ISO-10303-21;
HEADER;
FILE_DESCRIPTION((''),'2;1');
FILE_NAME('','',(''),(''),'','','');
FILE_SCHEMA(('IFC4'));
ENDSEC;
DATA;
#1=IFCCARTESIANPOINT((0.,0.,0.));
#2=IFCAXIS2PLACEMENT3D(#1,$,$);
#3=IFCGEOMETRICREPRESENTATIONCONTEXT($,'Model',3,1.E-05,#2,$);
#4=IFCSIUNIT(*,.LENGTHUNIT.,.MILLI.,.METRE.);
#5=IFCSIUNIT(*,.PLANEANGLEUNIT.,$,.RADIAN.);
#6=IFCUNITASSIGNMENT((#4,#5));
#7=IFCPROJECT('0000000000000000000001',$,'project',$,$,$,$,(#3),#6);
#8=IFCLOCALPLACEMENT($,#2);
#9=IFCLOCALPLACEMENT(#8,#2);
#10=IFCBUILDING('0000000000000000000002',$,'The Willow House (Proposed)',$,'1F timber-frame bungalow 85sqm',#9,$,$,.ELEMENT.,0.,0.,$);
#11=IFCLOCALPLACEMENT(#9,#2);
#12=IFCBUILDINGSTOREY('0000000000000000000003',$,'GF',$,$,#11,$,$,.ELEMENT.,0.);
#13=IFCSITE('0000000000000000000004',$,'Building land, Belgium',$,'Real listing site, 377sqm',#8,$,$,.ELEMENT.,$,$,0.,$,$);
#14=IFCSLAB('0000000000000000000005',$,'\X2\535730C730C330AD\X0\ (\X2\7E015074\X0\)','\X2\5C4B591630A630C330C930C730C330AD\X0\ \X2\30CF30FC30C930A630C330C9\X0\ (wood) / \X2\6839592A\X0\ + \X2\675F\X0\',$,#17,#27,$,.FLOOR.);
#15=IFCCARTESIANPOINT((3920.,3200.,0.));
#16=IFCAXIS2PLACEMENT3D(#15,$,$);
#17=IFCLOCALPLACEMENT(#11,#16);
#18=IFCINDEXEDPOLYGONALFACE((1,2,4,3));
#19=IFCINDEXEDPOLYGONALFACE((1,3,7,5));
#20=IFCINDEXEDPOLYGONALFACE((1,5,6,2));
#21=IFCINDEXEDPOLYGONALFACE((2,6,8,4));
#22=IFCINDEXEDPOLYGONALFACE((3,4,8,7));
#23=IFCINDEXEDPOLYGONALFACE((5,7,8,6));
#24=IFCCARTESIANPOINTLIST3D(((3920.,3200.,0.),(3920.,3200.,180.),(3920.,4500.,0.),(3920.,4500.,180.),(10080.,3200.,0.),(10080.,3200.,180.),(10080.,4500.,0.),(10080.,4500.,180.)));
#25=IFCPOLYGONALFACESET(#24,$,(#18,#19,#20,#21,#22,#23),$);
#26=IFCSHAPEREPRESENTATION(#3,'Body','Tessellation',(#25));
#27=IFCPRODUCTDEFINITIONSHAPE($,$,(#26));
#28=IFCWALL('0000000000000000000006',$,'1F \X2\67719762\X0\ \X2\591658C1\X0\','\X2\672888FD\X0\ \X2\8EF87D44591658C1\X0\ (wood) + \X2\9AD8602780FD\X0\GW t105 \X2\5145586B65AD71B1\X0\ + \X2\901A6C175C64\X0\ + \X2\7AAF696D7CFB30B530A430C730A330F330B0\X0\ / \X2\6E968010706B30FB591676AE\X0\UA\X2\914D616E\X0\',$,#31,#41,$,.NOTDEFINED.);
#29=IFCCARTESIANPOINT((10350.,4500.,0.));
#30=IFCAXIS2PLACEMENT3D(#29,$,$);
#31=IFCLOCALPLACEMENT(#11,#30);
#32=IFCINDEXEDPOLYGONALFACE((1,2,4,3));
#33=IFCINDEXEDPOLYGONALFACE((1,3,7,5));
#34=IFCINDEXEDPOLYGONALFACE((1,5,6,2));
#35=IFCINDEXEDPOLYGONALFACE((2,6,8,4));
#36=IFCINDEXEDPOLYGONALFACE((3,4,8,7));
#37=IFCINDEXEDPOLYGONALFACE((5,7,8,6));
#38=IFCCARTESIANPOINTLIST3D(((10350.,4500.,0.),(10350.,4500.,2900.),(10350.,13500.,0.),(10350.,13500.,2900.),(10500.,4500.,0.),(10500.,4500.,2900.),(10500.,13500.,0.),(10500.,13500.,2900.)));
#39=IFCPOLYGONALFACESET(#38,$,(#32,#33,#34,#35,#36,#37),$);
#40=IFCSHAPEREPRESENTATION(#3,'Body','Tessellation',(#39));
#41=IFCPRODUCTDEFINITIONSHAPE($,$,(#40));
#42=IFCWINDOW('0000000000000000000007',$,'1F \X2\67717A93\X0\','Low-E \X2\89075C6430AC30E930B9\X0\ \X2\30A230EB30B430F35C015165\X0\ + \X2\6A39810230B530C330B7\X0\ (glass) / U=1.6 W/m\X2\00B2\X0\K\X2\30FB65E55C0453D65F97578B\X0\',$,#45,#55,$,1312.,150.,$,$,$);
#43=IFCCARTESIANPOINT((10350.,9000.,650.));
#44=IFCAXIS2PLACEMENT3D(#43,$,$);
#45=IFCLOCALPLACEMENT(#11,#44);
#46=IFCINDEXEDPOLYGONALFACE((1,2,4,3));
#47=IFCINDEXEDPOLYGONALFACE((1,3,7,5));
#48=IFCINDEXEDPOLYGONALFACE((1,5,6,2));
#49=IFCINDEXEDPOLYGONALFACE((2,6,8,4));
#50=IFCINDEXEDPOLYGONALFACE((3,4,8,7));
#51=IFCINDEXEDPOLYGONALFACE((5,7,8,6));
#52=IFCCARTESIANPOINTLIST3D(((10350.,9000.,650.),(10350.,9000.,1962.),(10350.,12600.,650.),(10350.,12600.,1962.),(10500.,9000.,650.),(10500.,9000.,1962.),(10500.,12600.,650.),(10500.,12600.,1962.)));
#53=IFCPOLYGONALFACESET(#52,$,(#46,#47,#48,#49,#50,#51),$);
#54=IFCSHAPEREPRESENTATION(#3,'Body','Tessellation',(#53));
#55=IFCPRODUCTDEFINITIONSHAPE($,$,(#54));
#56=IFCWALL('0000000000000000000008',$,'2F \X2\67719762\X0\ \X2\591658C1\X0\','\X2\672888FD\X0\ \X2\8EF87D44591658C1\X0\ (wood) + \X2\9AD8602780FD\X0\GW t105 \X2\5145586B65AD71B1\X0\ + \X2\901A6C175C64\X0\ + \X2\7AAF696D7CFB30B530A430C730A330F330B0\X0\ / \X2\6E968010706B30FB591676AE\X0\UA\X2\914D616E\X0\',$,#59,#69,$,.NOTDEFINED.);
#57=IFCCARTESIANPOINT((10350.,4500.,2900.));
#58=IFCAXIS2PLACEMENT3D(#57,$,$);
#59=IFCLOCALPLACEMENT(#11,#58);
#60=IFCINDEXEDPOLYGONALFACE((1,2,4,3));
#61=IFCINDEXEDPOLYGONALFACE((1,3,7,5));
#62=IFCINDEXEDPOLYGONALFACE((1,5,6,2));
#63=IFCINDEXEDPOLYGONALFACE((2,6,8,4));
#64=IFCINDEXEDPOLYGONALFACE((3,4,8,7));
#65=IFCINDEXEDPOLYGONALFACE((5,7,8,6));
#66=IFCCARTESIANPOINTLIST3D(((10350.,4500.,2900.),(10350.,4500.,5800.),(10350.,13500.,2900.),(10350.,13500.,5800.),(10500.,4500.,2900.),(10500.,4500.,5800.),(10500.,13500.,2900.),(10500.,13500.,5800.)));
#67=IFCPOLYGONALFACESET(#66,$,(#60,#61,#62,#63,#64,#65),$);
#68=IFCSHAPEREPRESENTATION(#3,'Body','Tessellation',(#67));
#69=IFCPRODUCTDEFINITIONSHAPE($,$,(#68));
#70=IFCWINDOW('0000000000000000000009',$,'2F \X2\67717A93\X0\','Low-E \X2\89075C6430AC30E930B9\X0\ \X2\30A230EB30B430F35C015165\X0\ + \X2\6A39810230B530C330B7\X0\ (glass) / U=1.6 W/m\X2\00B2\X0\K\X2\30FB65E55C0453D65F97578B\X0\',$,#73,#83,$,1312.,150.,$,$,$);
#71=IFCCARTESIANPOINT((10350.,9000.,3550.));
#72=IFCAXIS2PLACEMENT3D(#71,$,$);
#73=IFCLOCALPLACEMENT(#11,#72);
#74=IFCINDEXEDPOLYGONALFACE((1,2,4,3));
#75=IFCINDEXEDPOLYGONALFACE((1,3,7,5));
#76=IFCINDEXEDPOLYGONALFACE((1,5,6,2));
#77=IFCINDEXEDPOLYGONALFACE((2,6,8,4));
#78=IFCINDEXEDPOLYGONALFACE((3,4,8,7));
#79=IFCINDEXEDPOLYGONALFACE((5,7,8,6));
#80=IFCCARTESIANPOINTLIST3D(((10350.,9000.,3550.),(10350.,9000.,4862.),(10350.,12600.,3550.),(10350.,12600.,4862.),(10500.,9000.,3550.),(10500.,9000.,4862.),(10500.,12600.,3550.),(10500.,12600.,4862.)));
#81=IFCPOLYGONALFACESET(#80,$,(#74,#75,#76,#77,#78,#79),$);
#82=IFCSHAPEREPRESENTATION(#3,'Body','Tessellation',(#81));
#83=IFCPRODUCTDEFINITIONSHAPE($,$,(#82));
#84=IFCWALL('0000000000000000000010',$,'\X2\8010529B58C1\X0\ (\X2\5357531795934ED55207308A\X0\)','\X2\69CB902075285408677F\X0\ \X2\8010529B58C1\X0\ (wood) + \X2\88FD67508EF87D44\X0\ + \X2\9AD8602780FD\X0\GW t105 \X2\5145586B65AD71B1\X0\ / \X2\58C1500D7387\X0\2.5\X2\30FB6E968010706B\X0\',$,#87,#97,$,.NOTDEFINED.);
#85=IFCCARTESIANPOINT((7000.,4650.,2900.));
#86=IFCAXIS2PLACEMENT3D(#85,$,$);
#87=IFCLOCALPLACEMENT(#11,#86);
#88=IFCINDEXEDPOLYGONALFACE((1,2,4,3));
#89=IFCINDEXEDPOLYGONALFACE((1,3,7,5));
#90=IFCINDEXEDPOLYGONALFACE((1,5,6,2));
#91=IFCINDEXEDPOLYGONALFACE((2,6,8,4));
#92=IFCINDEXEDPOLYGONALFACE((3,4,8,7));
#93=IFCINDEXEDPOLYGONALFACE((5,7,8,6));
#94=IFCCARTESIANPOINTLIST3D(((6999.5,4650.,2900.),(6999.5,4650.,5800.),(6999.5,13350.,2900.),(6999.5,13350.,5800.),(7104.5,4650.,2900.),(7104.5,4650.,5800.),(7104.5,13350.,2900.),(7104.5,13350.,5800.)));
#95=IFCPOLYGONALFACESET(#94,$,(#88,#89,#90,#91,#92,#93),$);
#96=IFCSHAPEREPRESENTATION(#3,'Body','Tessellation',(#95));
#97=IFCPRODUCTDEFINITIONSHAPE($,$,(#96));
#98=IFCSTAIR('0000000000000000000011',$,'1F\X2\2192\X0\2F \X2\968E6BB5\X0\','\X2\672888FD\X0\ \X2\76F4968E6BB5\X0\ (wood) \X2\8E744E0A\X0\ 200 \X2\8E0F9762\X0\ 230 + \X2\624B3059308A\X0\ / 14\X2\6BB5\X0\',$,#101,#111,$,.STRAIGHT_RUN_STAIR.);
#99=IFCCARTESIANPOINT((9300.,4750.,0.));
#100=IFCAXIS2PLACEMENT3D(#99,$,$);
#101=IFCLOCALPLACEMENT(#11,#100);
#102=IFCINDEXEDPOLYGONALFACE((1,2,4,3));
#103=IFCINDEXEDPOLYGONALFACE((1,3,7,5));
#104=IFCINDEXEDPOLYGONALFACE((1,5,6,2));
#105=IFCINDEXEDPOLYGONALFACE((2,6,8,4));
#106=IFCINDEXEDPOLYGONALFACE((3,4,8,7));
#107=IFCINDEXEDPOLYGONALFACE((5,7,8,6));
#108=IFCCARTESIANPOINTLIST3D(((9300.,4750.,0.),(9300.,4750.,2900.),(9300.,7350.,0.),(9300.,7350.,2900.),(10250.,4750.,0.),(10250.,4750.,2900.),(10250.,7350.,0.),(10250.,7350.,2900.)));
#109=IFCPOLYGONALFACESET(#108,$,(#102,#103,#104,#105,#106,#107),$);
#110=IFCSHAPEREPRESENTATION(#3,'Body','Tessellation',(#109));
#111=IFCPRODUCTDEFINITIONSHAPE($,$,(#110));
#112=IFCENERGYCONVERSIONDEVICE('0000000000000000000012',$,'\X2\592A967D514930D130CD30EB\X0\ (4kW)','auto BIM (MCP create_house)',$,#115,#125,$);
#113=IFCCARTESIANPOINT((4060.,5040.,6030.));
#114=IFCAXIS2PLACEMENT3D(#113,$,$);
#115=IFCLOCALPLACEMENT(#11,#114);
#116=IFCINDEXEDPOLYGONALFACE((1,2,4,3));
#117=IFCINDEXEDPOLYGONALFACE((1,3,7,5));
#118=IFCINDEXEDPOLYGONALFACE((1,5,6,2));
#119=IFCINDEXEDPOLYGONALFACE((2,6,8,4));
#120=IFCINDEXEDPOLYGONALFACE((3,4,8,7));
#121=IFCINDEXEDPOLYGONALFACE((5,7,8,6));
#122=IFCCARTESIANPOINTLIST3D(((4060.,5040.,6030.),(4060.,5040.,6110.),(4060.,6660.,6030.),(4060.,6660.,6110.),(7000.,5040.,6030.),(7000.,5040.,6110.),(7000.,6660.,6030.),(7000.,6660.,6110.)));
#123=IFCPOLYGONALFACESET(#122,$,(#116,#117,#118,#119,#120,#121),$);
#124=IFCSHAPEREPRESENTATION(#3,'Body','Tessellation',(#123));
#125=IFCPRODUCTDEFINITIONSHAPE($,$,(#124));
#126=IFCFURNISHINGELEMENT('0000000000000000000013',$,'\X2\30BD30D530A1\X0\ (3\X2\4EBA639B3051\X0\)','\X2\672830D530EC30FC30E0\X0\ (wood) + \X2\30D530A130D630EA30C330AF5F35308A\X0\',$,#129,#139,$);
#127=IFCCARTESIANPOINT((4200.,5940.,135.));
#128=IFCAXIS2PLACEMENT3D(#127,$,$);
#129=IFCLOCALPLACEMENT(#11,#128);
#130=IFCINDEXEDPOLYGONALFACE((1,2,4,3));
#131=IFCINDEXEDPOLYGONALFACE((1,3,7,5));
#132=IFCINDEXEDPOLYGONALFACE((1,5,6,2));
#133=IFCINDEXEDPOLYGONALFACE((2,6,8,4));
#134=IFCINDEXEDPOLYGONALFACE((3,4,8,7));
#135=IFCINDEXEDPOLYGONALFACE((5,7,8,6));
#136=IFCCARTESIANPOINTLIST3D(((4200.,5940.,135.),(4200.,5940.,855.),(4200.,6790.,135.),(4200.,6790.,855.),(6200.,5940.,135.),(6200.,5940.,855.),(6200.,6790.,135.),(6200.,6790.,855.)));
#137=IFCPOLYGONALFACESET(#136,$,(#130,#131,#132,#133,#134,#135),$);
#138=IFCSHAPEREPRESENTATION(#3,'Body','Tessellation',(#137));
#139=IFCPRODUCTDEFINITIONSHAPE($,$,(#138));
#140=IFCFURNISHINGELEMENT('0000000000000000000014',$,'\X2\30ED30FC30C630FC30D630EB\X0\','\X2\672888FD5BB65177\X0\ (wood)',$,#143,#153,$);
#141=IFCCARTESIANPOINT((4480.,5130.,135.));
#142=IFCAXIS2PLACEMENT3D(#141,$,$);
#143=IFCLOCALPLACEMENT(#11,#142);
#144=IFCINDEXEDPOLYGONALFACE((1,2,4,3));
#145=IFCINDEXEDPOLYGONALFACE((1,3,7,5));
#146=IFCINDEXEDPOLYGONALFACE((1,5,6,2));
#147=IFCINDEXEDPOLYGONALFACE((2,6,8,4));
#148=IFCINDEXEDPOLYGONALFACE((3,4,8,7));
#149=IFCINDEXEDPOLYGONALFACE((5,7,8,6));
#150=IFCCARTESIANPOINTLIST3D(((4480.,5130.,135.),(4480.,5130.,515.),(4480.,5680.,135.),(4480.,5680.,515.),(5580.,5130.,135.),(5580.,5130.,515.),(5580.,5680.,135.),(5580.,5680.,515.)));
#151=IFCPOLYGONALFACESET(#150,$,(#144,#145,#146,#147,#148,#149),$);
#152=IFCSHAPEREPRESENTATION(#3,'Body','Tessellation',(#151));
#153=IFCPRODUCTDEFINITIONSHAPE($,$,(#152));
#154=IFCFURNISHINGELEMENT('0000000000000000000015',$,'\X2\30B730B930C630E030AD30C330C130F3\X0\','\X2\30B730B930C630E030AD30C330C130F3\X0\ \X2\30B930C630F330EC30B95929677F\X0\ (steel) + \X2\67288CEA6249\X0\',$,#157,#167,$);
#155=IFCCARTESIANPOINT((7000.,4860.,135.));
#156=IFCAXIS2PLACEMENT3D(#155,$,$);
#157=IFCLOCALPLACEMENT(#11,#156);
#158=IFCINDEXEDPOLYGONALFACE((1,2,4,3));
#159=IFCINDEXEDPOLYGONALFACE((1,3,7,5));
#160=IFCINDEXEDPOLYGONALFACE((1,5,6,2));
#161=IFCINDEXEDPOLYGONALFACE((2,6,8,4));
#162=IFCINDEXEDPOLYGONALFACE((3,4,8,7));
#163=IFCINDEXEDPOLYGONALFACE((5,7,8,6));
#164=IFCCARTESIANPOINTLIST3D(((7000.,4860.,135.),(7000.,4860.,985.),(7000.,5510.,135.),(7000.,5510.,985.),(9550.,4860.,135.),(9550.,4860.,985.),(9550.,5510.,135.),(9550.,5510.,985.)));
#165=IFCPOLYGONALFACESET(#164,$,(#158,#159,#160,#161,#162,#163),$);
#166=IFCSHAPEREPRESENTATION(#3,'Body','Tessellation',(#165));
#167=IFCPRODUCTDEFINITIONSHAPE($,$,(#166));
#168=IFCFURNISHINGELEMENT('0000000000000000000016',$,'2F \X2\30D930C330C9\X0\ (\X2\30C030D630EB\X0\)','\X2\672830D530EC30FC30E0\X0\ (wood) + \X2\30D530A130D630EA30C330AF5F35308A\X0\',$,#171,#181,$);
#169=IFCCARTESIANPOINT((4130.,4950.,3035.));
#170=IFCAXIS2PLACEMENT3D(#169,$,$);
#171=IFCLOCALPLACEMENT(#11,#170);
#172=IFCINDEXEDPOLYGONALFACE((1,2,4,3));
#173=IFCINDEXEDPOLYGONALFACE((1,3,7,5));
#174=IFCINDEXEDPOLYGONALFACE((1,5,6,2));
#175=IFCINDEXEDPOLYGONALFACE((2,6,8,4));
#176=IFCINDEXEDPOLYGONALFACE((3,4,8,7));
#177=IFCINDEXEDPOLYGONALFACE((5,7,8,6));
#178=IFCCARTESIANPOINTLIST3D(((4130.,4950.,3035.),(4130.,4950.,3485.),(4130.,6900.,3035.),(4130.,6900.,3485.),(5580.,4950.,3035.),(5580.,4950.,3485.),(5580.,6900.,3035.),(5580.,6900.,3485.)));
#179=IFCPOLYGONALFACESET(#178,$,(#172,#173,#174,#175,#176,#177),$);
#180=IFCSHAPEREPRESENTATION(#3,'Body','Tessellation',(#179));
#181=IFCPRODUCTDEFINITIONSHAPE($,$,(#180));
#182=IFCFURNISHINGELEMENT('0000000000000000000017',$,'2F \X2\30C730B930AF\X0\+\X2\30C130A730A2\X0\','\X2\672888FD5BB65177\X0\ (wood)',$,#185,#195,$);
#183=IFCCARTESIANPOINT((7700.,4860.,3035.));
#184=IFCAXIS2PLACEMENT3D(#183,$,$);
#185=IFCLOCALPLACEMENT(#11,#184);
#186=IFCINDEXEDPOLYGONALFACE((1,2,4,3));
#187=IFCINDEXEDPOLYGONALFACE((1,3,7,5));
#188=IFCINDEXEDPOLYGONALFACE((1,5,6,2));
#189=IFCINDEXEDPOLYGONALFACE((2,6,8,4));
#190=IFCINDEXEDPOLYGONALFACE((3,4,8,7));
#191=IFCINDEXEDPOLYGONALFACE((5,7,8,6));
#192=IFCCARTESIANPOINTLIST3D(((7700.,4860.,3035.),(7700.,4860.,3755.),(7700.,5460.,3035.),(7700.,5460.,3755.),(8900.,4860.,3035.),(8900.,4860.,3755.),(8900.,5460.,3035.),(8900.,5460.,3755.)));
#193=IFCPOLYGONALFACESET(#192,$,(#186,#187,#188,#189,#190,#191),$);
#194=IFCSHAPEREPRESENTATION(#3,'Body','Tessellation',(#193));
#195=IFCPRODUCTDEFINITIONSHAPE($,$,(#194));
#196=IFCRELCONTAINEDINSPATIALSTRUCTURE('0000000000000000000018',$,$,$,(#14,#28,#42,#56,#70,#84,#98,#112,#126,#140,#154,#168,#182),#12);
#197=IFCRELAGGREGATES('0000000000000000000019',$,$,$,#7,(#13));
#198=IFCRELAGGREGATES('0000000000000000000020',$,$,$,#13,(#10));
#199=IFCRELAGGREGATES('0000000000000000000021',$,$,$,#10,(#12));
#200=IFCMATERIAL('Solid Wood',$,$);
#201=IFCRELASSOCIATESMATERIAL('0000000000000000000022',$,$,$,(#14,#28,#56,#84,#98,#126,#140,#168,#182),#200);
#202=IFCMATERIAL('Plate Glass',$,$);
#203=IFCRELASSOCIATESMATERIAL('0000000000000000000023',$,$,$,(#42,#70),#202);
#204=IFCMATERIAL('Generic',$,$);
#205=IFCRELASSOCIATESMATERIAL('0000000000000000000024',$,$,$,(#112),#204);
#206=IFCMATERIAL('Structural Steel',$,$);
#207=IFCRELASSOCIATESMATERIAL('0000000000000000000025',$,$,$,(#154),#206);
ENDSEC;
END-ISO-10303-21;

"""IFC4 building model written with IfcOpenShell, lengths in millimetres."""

from ifc_helpers import new_model, si_unit, frame, frame_2d, origin, place, context, project, spatial, rectangle, extrude, material, element, fill, save


model = new_model("IFC4")

# Units and contexts
model_context = context("Model", 3, precision=1e-05, world=origin())
ifc_project = project(units=[si_unit("LENGTHUNIT", "METRE", prefix="MILLI"), si_unit("PLANEANGLEUNIT", "RADIAN")], contexts=[model_context])

# Site, building, storey
site_placement = place(None, origin())
site = spatial("IfcSite", under=ifc_project, at=site_placement, Name="Building land, Belgium", ObjectType="Real listing site, 377sqm", CompositionType="ELEMENT", RefElevation=0.0)
building_placement = place(site_placement, origin())
building = spatial("IfcBuilding", under=site, at=building_placement, Name="The Willow House (Proposed)", ObjectType="1F timber-frame bungalow 85sqm", CompositionType="ELEMENT", ElevationOfRefHeight=0.0, ElevationOfTerrain=0.0)
storey_placement = place(building_placement, origin())
storey = spatial("IfcBuildingStorey", under=building, at=storey_placement, Name="GF", CompositionType="ELEMENT", Elevation=0.0)

# Slab
ifc_material_1 = material(Name="Solid Wood")
slab_placement = place(storey_placement, frame((3920.0, 3200.0, 0.0)))
element("IfcSlab", 1, at=slab_placement, inside=storey, material=ifc_material_1, Name="南デッキ (縁側)", Description="屋外ウッドデッキ ハードウッド (wood) / 根太 + 束", PredefinedType="FLOOR", context=model_context, shape_type="SweptSolid", body=[
    extrude(rectangle(XDim=6160.0, YDim=1300.0, at=frame_2d((3080.0, 650.0))), frame((3920.0, 3200.0, 0.0)), (0.0, 0.0, 1.0), 180.0),
])

# Wall, opening, window
wall_1_placement = place(storey_placement, frame((10350.0, 4500.0, 0.0)))
wall_1 = element("IfcWall", 2, at=wall_1_placement, inside=storey, material=ifc_material_1, Name="1F 東面 外壁", Description="木製 軸組外壁 (wood) + 高性能GW t105 充填断熱 + 通気層 + 窯業系サイディング / 準耐火・外皮UA配慮", PredefinedType="NOTDEFINED", context=model_context, shape_type="SweptSolid", body=[
    extrude(rectangle(XDim=150.0, YDim=9000.0, at=frame_2d((75.0, 4500.0))), frame((10350.0, 4500.0, 0.0)), (0.0, 0.0, 1.0), 2900.0),
])
opening_1_placement = place(storey_placement, frame((10350.0, 9000.0, 650.0)))
opening_1 = element("IfcOpeningElement", 3, at=opening_1_placement, cuts=wall_1, PredefinedType="NOTDEFINED", context=model_context, shape_type="SweptSolid", body=[
    extrude(rectangle(XDim=150.0, YDim=3600.0, at=frame_2d((75.0, 1800.0))), frame((10350.0, 9000.0, 650.0)), (0.0, 0.0, 1.0), 1312.0),
])
ifc_material_2 = material(Name="Plate Glass")
window_1_placement = place(storey_placement, frame((10350.0, 9000.0, 650.0)))
window_1 = element("IfcWindow", 4, at=window_1_placement, inside=storey, material=ifc_material_2, Name="1F 東窓", Description="Low-E 複層ガラス アルゴン封入 + 樹脂サッシ (glass) / U=1.6 W/m²K・日射取得型", OverallHeight=1312.0, OverallWidth=150.0, context=model_context, shape_type="SweptSolid", body=[
    extrude(rectangle(XDim=150.0, YDim=3600.0, at=frame_2d((75.0, 1800.0))), frame((10350.0, 9000.0, 650.0)), (0.0, 0.0, 1.0), 1312.0),
])
fill(opening_1, window_1)

# Wall, opening, window
wall_2_placement = place(storey_placement, frame((10350.0, 4500.0, 2900.0)))
wall_2 = element("IfcWall", 5, at=wall_2_placement, inside=storey, material=ifc_material_1, Name="2F 東面 外壁", Description="木製 軸組外壁 (wood) + 高性能GW t105 充填断熱 + 通気層 + 窯業系サイディング / 準耐火・外皮UA配慮", PredefinedType="NOTDEFINED", context=model_context, shape_type="SweptSolid", body=[
    extrude(rectangle(XDim=150.0, YDim=9000.0, at=frame_2d((75.0, 4500.0))), frame((10350.0, 4500.0, 2900.0)), (0.0, 0.0, 1.0), 2900.0),
])
opening_2_placement = place(storey_placement, frame((10350.0, 9000.0, 3550.0)))
opening_2 = element("IfcOpeningElement", 6, at=opening_2_placement, cuts=wall_2, PredefinedType="NOTDEFINED", context=model_context, shape_type="SweptSolid", body=[
    extrude(rectangle(XDim=150.0, YDim=3600.0, at=frame_2d((75.0, 1800.0))), frame((10350.0, 9000.0, 3550.0)), (0.0, 0.0, 1.0), 1312.0),
])
window_2_placement = place(storey_placement, frame((10350.0, 9000.0, 3550.0)))
window_2 = element("IfcWindow", 7, at=window_2_placement, inside=storey, material=ifc_material_2, Name="2F 東窓", Description="Low-E 複層ガラス アルゴン封入 + 樹脂サッシ (glass) / U=1.6 W/m²K・日射取得型", OverallHeight=1312.0, OverallWidth=150.0, context=model_context, shape_type="SweptSolid", body=[
    extrude(rectangle(XDim=150.0, YDim=3600.0, at=frame_2d((75.0, 1800.0))), frame((10350.0, 9000.0, 3550.0)), (0.0, 0.0, 1.0), 1312.0),
])
fill(opening_2, window_2)

# Wall
wall_3_placement = place(storey_placement, frame((7000.0, 4650.0, 2900.0)))
element("IfcWall", 8, at=wall_3_placement, inside=storey, material=ifc_material_1, Name="耐力壁 (南北間仕切り)", Description="構造用合板 耐力壁 (wood) + 製材軸組 + 高性能GW t105 充填断熱 / 壁倍率2.5・準耐火", PredefinedType="NOTDEFINED", context=model_context, shape_type="SweptSolid", body=[
    extrude(rectangle(XDim=105.0, YDim=8700.0, at=frame_2d((52.0, 4350.0))), frame((7000.0, 4650.0, 2900.0)), (0.0, 0.0, 1.0), 2900.0),
])

# Stair
stair_placement = place(storey_placement, frame((9300.0, 4750.0, 0.0)))
element("IfcStair", 9, at=stair_placement, inside=storey, material=ifc_material_1, Name="1F→2F 階段", Description="木製 直階段 (wood) 蹴上 200 踏面 230 + 手すり / 14段", PredefinedType="STRAIGHT_RUN_STAIR", context=model_context, shape_type="SweptSolid", body=[
    extrude(rectangle(XDim=950.0, YDim=2600.0, at=frame_2d((475.0, 1300.0))), frame((9300.0, 4750.0, 0.0)), (0.0, 0.0, 1.0), 2900.0),
])

# Energy conversion device
ifc_material_3 = material(Name="Generic")
energy_conversion_device_placement = place(storey_placement, frame((4060.0, 5040.0, 6030.0)))
element("IfcEnergyConversionDevice", 10, at=energy_conversion_device_placement, inside=storey, material=ifc_material_3, Name="太陽光パネル (4kW)", Description="auto BIM (MCP create_house)", context=model_context, shape_type="SweptSolid", body=[
    extrude(rectangle(XDim=2940.0, YDim=1620.0, at=frame_2d((1470.0, 810.0))), frame((4060.0, 5040.0, 6030.0)), (0.0, 0.0, 1.0), 80.0),
])

# Furnishing elements
furnishing_1_placement = place(storey_placement, frame((4200.0, 5940.0, 135.0)))
element("IfcFurnishingElement", 11, at=furnishing_1_placement, inside=storey, material=ifc_material_1, Name="ソファ (3人掛け)", Description="木フレーム (wood) + ファブリック張り", context=model_context, shape_type="SweptSolid", body=[
    extrude(rectangle(XDim=2000.0, YDim=850.0, at=frame_2d((1000.0, 425.0))), frame((4200.0, 5940.0, 135.0)), (0.0, 0.0, 1.0), 720.0),
])
furnishing_2_placement = place(storey_placement, frame((4480.0, 5130.0, 135.0)))
element("IfcFurnishingElement", 12, at=furnishing_2_placement, inside=storey, material=ifc_material_1, Name="ローテーブル", Description="木製家具 (wood)", context=model_context, shape_type="SweptSolid", body=[
    extrude(rectangle(XDim=1100.0, YDim=550.0, at=frame_2d((550.0, 275.0))), frame((4480.0, 5130.0, 135.0)), (0.0, 0.0, 1.0), 380.0),
])
ifc_material_4 = material(Name="Structural Steel")
furnishing_3_placement = place(storey_placement, frame((7000.0, 4860.0, 135.0)))
element("IfcFurnishingElement", 13, at=furnishing_3_placement, inside=storey, material=ifc_material_4, Name="システムキッチン", Description="システムキッチン ステンレス天板 (steel) + 木質扉", context=model_context, shape_type="SweptSolid", body=[
    extrude(rectangle(XDim=2550.0, YDim=650.0, at=frame_2d((1275.0, 325.0))), frame((7000.0, 4860.0, 135.0)), (0.0, 0.0, 1.0), 850.0),
])
furnishing_4_placement = place(storey_placement, frame((4130.0, 4950.0, 3035.0)))
element("IfcFurnishingElement", 14, at=furnishing_4_placement, inside=storey, material=ifc_material_1, Name="2F ベッド (ダブル)", Description="木フレーム (wood) + ファブリック張り", context=model_context, shape_type="SweptSolid", body=[
    extrude(rectangle(XDim=1450.0, YDim=1950.0, at=frame_2d((725.0, 975.0))), frame((4130.0, 4950.0, 3035.0)), (0.0, 0.0, 1.0), 450.0),
])
furnishing_5_placement = place(storey_placement, frame((7700.0, 4860.0, 3035.0)))
element("IfcFurnishingElement", 15, at=furnishing_5_placement, inside=storey, material=ifc_material_1, Name="2F デスク+チェア", Description="木製家具 (wood)", context=model_context, shape_type="SweptSolid", body=[
    extrude(rectangle(XDim=1200.0, YDim=600.0, at=frame_2d((600.0, 300.0))), frame((7700.0, 4860.0, 3035.0)), (0.0, 0.0, 1.0), 720.0),
])

save(model, "model.ifc")
